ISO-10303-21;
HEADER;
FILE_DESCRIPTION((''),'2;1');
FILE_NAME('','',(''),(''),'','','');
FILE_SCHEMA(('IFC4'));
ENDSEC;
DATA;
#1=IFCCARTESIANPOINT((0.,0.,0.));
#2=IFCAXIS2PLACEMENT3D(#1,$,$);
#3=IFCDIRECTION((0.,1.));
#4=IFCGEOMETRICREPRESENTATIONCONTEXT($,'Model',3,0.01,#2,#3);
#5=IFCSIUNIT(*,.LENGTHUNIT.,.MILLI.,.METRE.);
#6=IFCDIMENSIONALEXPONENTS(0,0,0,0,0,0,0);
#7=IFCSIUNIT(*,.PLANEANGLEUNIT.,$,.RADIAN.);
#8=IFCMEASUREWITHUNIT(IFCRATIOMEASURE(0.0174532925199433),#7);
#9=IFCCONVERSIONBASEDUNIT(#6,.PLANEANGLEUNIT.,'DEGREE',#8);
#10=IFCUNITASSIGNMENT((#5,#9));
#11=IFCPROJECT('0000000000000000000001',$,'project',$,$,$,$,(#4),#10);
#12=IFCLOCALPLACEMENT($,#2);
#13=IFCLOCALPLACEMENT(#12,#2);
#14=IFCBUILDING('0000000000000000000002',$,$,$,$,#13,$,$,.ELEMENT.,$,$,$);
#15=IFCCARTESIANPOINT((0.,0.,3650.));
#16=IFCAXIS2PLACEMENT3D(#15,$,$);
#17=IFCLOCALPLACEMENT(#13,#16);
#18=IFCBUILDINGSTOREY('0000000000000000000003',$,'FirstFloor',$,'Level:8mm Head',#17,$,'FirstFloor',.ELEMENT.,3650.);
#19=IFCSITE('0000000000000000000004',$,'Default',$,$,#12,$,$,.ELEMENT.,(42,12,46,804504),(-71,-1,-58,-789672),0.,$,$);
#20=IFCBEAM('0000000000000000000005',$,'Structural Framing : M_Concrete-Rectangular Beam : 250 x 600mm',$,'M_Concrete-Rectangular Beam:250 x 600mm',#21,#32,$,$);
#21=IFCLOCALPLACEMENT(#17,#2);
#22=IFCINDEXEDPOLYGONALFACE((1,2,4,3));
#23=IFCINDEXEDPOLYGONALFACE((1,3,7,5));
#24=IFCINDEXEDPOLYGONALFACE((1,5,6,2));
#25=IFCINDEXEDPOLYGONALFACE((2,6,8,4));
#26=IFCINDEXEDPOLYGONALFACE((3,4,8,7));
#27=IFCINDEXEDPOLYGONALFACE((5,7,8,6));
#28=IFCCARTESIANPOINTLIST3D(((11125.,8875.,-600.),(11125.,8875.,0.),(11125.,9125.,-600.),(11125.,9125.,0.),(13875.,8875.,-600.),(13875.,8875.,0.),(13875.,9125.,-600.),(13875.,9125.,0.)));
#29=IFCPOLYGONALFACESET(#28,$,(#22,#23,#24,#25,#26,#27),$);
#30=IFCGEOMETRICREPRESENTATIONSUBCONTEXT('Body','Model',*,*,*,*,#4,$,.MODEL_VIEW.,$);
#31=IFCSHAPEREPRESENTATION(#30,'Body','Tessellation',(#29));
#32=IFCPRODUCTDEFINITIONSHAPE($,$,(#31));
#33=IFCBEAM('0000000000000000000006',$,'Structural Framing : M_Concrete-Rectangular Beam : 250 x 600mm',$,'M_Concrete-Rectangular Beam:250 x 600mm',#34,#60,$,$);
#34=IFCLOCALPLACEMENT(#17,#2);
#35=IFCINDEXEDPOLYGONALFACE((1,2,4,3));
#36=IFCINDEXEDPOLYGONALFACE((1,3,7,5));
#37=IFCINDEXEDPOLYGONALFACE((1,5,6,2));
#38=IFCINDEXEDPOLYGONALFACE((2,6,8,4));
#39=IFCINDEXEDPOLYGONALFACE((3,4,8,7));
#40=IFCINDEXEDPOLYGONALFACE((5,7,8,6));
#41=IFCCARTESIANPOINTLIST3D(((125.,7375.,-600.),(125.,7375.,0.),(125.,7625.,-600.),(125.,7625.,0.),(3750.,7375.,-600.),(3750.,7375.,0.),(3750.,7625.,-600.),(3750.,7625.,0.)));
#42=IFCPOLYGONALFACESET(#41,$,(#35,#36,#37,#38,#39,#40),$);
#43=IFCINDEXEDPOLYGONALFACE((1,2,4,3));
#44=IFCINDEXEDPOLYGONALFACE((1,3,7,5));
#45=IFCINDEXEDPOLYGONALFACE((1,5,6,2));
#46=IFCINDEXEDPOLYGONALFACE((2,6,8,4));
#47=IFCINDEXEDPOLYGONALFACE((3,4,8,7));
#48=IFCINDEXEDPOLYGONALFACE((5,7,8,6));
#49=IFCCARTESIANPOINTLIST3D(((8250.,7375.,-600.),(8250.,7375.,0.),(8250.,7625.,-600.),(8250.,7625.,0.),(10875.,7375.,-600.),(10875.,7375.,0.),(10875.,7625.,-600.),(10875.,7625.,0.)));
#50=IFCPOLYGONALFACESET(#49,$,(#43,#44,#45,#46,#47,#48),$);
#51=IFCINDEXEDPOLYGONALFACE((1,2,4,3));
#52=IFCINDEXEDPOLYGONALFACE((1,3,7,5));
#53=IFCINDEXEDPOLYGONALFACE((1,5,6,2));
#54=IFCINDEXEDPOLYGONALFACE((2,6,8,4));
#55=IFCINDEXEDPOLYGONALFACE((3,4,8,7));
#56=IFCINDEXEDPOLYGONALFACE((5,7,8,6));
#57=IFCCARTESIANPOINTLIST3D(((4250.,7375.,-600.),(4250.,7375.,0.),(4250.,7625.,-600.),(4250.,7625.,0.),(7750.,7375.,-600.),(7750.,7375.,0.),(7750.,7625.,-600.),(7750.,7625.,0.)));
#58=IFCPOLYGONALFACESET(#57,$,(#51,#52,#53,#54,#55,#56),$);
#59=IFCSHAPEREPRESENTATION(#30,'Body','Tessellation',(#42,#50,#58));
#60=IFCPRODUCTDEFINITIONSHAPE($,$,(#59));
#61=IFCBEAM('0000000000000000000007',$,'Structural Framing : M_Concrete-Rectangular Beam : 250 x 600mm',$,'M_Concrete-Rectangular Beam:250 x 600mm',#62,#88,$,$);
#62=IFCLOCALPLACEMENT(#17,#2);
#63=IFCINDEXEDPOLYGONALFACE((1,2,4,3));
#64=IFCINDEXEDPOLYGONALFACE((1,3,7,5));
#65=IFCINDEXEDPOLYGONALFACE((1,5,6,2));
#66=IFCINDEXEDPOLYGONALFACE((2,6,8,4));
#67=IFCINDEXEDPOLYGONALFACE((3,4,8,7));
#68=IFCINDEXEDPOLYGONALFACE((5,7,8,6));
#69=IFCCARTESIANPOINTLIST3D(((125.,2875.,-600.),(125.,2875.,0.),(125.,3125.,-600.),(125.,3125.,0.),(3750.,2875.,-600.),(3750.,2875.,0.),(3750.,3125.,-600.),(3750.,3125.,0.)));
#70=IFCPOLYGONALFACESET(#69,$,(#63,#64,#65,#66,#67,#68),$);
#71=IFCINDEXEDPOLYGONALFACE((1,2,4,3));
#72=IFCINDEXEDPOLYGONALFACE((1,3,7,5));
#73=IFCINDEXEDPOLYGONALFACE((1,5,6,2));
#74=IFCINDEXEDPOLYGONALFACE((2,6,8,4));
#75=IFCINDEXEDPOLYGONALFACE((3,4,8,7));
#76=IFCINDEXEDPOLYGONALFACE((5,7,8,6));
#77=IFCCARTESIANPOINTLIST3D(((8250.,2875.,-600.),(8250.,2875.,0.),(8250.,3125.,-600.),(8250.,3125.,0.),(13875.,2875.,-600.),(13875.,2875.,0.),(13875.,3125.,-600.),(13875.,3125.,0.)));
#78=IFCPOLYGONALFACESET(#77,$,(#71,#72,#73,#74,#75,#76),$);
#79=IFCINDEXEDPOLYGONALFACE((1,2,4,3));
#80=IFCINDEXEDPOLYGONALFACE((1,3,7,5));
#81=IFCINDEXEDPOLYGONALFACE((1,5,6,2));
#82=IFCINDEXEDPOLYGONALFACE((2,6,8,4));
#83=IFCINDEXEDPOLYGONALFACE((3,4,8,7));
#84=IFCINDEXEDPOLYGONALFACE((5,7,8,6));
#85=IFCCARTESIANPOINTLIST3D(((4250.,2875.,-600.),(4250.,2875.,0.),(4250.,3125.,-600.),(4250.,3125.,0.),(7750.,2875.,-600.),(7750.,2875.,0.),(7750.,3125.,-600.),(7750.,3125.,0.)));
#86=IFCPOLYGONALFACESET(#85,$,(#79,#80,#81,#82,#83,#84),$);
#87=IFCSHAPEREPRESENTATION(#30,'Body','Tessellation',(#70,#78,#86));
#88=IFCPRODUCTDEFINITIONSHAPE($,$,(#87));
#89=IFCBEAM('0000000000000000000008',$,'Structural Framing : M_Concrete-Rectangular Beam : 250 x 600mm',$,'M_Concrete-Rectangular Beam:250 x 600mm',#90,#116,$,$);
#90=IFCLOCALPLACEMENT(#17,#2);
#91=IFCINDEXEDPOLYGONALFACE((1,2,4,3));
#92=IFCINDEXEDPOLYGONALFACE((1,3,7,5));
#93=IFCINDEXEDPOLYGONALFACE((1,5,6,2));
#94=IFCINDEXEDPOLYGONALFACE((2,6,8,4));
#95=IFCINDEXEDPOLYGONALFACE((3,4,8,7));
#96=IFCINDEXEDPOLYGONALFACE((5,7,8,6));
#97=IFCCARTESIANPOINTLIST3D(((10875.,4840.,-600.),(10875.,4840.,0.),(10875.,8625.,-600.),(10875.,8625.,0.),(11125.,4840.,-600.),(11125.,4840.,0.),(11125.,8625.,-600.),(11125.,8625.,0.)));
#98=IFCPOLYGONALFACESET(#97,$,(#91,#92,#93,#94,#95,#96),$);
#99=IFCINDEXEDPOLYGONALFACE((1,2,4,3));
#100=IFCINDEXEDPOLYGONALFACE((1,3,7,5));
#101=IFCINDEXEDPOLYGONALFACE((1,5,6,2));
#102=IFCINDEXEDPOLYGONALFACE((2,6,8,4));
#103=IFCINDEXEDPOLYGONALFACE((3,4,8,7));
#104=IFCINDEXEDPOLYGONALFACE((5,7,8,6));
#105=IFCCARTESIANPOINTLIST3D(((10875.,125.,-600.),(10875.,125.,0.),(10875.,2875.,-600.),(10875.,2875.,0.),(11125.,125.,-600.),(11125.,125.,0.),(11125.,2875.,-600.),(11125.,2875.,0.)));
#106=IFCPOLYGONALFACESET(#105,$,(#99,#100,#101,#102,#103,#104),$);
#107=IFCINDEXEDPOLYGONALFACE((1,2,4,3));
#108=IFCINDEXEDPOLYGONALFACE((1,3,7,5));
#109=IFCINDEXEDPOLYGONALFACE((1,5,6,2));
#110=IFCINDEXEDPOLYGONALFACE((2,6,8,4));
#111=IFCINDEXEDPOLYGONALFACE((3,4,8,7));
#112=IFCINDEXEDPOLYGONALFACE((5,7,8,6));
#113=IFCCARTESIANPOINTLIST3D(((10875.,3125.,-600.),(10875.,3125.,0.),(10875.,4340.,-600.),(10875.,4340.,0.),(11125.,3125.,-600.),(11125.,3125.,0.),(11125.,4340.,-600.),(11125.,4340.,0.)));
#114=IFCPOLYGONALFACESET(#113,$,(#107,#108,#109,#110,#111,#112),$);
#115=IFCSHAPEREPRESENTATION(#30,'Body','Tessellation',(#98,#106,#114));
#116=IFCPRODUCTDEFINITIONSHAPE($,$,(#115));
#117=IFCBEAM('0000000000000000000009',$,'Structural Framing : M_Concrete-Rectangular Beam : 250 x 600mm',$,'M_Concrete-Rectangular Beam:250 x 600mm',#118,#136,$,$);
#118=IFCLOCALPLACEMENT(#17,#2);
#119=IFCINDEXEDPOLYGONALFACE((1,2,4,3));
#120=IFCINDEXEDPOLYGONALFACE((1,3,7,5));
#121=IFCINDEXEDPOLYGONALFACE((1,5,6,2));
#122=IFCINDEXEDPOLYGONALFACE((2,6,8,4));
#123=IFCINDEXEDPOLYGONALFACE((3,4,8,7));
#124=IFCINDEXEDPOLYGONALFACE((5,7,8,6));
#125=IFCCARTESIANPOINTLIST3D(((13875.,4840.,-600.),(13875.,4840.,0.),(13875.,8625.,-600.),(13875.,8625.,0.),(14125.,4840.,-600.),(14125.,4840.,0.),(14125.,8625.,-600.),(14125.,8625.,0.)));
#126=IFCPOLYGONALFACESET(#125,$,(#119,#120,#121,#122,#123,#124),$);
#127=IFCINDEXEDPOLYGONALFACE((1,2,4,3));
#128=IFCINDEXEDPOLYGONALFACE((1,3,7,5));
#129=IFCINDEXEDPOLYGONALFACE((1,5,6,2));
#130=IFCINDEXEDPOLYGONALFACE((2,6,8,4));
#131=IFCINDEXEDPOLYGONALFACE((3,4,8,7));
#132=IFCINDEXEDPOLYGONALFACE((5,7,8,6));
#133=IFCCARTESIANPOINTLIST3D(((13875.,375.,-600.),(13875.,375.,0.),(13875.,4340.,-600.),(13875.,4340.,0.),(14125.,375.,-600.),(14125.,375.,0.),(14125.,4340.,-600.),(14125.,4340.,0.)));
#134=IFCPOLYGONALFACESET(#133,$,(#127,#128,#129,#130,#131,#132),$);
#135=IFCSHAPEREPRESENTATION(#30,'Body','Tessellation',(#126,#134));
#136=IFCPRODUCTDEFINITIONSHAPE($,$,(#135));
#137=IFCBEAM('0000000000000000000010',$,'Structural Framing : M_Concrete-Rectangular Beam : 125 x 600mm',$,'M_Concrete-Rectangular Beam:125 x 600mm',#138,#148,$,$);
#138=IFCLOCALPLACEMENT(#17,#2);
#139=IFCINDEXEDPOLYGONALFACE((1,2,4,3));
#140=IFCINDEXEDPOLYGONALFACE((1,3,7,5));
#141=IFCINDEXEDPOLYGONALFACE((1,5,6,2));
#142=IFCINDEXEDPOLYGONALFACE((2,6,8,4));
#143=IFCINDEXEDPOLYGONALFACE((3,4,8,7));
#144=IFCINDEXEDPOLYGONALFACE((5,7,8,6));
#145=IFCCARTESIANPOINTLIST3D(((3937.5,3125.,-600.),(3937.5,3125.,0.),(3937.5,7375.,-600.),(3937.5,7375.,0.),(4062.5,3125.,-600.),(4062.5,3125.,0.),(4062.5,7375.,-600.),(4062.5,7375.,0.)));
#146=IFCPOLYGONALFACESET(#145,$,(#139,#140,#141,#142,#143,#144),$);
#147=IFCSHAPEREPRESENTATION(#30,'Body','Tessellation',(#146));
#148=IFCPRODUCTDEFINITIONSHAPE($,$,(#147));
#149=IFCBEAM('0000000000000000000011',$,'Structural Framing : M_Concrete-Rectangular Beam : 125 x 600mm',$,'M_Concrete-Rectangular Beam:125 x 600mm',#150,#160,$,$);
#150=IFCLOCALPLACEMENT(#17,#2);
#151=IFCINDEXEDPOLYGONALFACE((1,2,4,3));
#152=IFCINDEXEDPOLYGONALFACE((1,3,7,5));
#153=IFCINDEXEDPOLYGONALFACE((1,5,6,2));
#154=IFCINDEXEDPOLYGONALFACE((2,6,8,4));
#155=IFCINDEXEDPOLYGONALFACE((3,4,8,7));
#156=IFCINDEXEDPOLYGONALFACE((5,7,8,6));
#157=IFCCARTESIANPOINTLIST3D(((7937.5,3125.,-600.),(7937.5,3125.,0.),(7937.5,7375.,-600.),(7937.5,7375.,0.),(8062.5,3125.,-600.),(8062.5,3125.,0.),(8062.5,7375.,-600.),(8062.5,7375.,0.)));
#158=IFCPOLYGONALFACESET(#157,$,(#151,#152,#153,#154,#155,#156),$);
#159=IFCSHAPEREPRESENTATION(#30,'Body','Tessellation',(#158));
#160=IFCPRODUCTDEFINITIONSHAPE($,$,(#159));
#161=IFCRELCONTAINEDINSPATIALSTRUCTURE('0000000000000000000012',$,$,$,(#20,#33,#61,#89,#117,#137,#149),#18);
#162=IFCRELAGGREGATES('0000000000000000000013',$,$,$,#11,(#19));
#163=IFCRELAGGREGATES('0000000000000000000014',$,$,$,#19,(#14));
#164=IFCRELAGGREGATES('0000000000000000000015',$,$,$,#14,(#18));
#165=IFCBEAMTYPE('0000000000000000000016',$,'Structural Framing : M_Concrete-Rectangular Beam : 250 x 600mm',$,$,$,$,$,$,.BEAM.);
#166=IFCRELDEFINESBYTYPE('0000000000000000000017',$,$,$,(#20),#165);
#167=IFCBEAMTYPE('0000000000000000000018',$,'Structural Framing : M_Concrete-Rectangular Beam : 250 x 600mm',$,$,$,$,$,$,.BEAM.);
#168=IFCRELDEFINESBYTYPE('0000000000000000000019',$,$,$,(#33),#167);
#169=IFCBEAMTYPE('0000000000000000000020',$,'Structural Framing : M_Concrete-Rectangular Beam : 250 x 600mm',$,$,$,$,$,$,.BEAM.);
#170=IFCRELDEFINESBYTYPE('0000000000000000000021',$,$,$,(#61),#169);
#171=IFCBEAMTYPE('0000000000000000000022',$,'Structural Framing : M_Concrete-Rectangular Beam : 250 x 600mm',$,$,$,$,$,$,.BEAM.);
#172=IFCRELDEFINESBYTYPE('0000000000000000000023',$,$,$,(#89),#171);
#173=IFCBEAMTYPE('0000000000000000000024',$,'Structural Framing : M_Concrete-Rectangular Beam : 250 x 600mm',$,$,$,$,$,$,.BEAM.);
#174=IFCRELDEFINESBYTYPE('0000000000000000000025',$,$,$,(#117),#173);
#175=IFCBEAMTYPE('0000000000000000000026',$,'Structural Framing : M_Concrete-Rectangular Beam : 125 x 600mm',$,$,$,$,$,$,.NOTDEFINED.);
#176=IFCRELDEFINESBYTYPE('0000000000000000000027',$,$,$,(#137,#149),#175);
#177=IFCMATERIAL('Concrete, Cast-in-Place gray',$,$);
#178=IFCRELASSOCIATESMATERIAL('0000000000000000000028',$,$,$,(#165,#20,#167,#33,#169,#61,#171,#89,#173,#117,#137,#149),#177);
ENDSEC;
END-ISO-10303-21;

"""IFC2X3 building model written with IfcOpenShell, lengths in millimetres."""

from ifc_helpers import new_model, entity, si_unit, converted_unit, direction, frame, frame_2d, origin, place, context, subcontext, project, spatial, rectangle, extrude, source, transform, mapped, material, type_object, type_shapes, element, save


model = new_model("IFC2X3")

# Units and contexts
model_context = context("Model", 3, precision=0.01, world=origin(), true_north=direction((0.0, 1.0)))
body_context = subcontext(model_context, "Body", "Model", "MODEL_VIEW")
ifc_project = project(units=[si_unit("LENGTHUNIT", "METRE", prefix="MILLI"), converted_unit("PLANEANGLEUNIT", "DEGREE", entity("IfcRatioMeasure", 0.0174532925199433), si_unit("PLANEANGLEUNIT", "RADIAN"), dimensions=[0, 0, 0, 0, 0, 0, 0])], contexts=[model_context])

# Site, building, storey
site_placement = place(None, origin())
site = spatial("IfcSite", under=ifc_project, at=site_placement, Name="Default", CompositionType="ELEMENT", RefLatitude=(42, 12, 46, 804504), RefLongitude=(-71, -1, -58, -789672), RefElevation=0.0)
building_placement = place(site_placement, origin())
building = spatial("IfcBuilding", under=site, at=building_placement, CompositionType="ELEMENT")
storey_placement = place(building_placement, frame((0.0, 0.0, 3650.0)))
storey = spatial("IfcBuildingStorey", under=building, at=storey_placement, Name="FirstFloor", ObjectType="Level:8mm Head", LongName="FirstFloor", CompositionType="ELEMENT", Elevation=3650.0)

# Shared definitions
ifc_material = material(Name="Concrete, Cast-in-Place gray")

# Beams
beam_type_1 = type_object("IfcBeamType", Name="Structural Framing : M_Concrete-Rectangular Beam : 250 x 600mm", PredefinedType="BEAM", material=ifc_material)
beam_1_placement = place(storey_placement, frame((11000.0, 9000.0, 0.0)))
element("IfcBeam", 1, at=beam_1_placement, inside=storey, type_object=beam_type_1, material=ifc_material, Name="Structural Framing : M_Concrete-Rectangular Beam : 250 x 600mm", ObjectType="M_Concrete-Rectangular Beam:250 x 600mm", context=body_context, shape_type="SweptSolid", body=[
    extrude(rectangle(XDim=600.0, YDim=250.0, at=frame_2d((0.0, 0.0), x_axis=(1.0, 0.0))), frame((125.0, 0.0, -300.0), z_axis=(1.0, 0.0, 0.0), x_axis=(0.0, 0.0, -1.0)), (0.0, 0.0, 1.0), 2750.0),
])
beam_type_2 = type_object("IfcBeamType", Name="Structural Framing : M_Concrete-Rectangular Beam : 250 x 600mm", PredefinedType="BEAM", material=ifc_material)
shared_shape_1 = source(origin(), body_context, "Body", "SweptSolid", [
    extrude(rectangle(XDim=600.0, YDim=250.0, at=frame_2d((0.0, 0.0), x_axis=(1.0, 0.0))), frame((125.0, 7500.0, 3350.0), z_axis=(1.0, 0.0, 0.0), x_axis=(0.0, 0.0, -1.0)), (0.0, 0.0, 1.0), 3625.0),
    extrude(rectangle(XDim=600.0, YDim=250.0, at=frame_2d((0.0, 0.0), x_axis=(1.0, 0.0))), frame((8250.0, 7500.0, 3350.0), z_axis=(1.0, 0.0, 0.0), x_axis=(0.0, 0.0, -1.0)), (0.0, 0.0, 1.0), 2625.0),
    extrude(rectangle(XDim=600.0, YDim=250.0, at=frame_2d((0.0, 0.0), x_axis=(1.0, 0.0))), frame((4250.0, 7500.0, 3350.0), z_axis=(1.0, 0.0, 0.0), x_axis=(0.0, 0.0, -1.0)), (0.0, 0.0, 1.0), 3500.0),
])
type_shapes(beam_type_2, [shared_shape_1])
beam_2_placement = place(storey_placement, frame((0.0, 0.0, -3650.0)))
element("IfcBeam", 2, at=beam_2_placement, inside=storey, type_object=beam_type_2, material=ifc_material, Name="Structural Framing : M_Concrete-Rectangular Beam : 250 x 600mm", ObjectType="M_Concrete-Rectangular Beam:250 x 600mm", context=body_context, shape_type="MappedRepresentation", body=[
    mapped(shared_shape_1, transform((0.0, 0.0, 0.0), scale=1.0)),
])
beam_type_3 = type_object("IfcBeamType", Name="Structural Framing : M_Concrete-Rectangular Beam : 250 x 600mm", PredefinedType="BEAM", material=ifc_material)
shared_shape_2 = source(origin(), body_context, "Body", "SweptSolid", [
    extrude(rectangle(XDim=600.0, YDim=250.0, at=frame_2d((0.0, 0.0), x_axis=(1.0, 0.0))), frame((125.0, 3000.0, 3350.0), z_axis=(1.0, 0.0, 0.0), x_axis=(0.0, 0.0, -1.0)), (0.0, 0.0, 1.0), 3625.0),
    extrude(rectangle(XDim=600.0, YDim=250.0, at=frame_2d((0.0, 0.0), x_axis=(1.0, 0.0))), frame((8250.0, 3000.0, 3350.0), z_axis=(1.0, 0.0, 0.0), x_axis=(0.0, 0.0, -1.0)), (0.0, 0.0, 1.0), 5625.0),
    extrude(rectangle(XDim=600.0, YDim=250.0, at=frame_2d((0.0, 0.0), x_axis=(1.0, 0.0))), frame((4250.0, 3000.0, 3350.0), z_axis=(1.0, 0.0, 0.0), x_axis=(0.0, 0.0, -1.0)), (0.0, 0.0, 1.0), 3500.0),
])
type_shapes(beam_type_3, [shared_shape_2])
beam_3_placement = place(storey_placement, frame((0.0, 0.0, -3650.0)))
element("IfcBeam", 3, at=beam_3_placement, inside=storey, type_object=beam_type_3, material=ifc_material, Name="Structural Framing : M_Concrete-Rectangular Beam : 250 x 600mm", ObjectType="M_Concrete-Rectangular Beam:250 x 600mm", context=body_context, shape_type="MappedRepresentation", body=[
    mapped(shared_shape_2, transform((0.0, 0.0, 0.0), scale=1.0)),
])
beam_type_4 = type_object("IfcBeamType", Name="Structural Framing : M_Concrete-Rectangular Beam : 250 x 600mm", PredefinedType="BEAM", material=ifc_material)
shared_shape_3 = source(origin(), body_context, "Body", "SweptSolid", [
    extrude(rectangle(XDim=600.0, YDim=250.0, at=frame_2d((0.0, 0.0), x_axis=(0.0, 1.0))), frame((11000.0, 4840.0, 3350.0), z_axis=(0.0, 1.0, 0.0), x_axis=(-1.0, 0.0, 0.0)), (0.0, 0.0, 1.0), 3785.0),
    extrude(rectangle(XDim=600.0, YDim=250.0, at=frame_2d((0.0, 0.0), x_axis=(0.0, 1.0))), frame((11000.0, 125.0, 3350.0), z_axis=(0.0, 1.0, 0.0), x_axis=(-1.0, 0.0, 0.0)), (0.0, 0.0, 1.0), 2750.0),
    extrude(rectangle(XDim=600.0, YDim=250.0, at=frame_2d((0.0, 0.0), x_axis=(0.0, 1.0))), frame((11000.0, 3125.0, 3350.0), z_axis=(0.0, 1.0, 0.0), x_axis=(-1.0, 0.0, 0.0)), (0.0, 0.0, 1.0), 1215.0),
])
type_shapes(beam_type_4, [shared_shape_3])
beam_4_placement = place(storey_placement, frame((0.0, 0.0, -3650.0)))
element("IfcBeam", 4, at=beam_4_placement, inside=storey, type_object=beam_type_4, material=ifc_material, Name="Structural Framing : M_Concrete-Rectangular Beam : 250 x 600mm", ObjectType="M_Concrete-Rectangular Beam:250 x 600mm", context=body_context, shape_type="MappedRepresentation", body=[
    mapped(shared_shape_3, transform((0.0, 0.0, 0.0), scale=1.0)),
])
beam_type_5 = type_object("IfcBeamType", Name="Structural Framing : M_Concrete-Rectangular Beam : 250 x 600mm", PredefinedType="BEAM", material=ifc_material)
shared_shape_4 = source(origin(), body_context, "Body", "SweptSolid", [
    extrude(rectangle(XDim=600.0, YDim=250.0, at=frame_2d((0.0, 0.0), x_axis=(0.0, 1.0))), frame((14000.0, 8625.0, 3350.0), z_axis=(0.0, -1.0, 0.0), x_axis=(-1.0, 0.0, 0.0)), (0.0, 0.0, 1.0), 3785.0),
    extrude(rectangle(XDim=600.0, YDim=250.0, at=frame_2d((0.0, 0.0), x_axis=(0.0, 1.0))), frame((14000.0, 4340.0, 3350.0), z_axis=(0.0, -1.0, 0.0), x_axis=(-1.0, 0.0, 0.0)), (0.0, 0.0, 1.0), 3965.0),
])
type_shapes(beam_type_5, [shared_shape_4])
beam_5_placement = place(storey_placement, frame((0.0, 0.0, -3650.0)))
element("IfcBeam", 5, at=beam_5_placement, inside=storey, type_object=beam_type_5, material=ifc_material, Name="Structural Framing : M_Concrete-Rectangular Beam : 250 x 600mm", ObjectType="M_Concrete-Rectangular Beam:250 x 600mm", context=body_context, shape_type="MappedRepresentation", body=[
    mapped(shared_shape_4, transform((0.0, 0.0, 0.0), scale=1.0)),
])
beam_type_6 = type_object("IfcBeamType", Name="Structural Framing : M_Concrete-Rectangular Beam : 125 x 600mm", PredefinedType="NOTDEFINED")
beam_6_placement = place(storey_placement, frame((4000.0, 3000.0, 0.0), z_axis=(0.0, 0.0, 1.0), x_axis=(0.0, 1.0, 0.0)))
element("IfcBeam", 6, at=beam_6_placement, inside=storey, type_object=beam_type_6, material=ifc_material, Name="Structural Framing : M_Concrete-Rectangular Beam : 125 x 600mm", ObjectType="M_Concrete-Rectangular Beam:125 x 600mm", context=body_context, shape_type="SweptSolid", body=[
    extrude(rectangle(XDim=600.0, YDim=125.0, at=frame_2d((0.0, 0.0), x_axis=(1.0, 0.0))), frame((125.0, 0.0, -300.0), z_axis=(1.0, 0.0, 0.0), x_axis=(0.0, 0.0, -1.0)), (0.0, 0.0, 1.0), 4250.0),
])
beam_7_placement = place(storey_placement, frame((8000.0, 3000.0, 0.0), z_axis=(0.0, 0.0, 1.0), x_axis=(0.0, 1.0, 0.0)))
element("IfcBeam", 7, at=beam_7_placement, inside=storey, type_object=beam_type_6, material=ifc_material, Name="Structural Framing : M_Concrete-Rectangular Beam : 125 x 600mm", ObjectType="M_Concrete-Rectangular Beam:125 x 600mm", context=body_context, shape_type="SweptSolid", body=[
    extrude(rectangle(XDim=600.0, YDim=125.0, at=frame_2d((0.0, 0.0), x_axis=(1.0, 0.0))), frame((125.0, 0.0, -300.0), z_axis=(1.0, 0.0, 0.0), x_axis=(0.0, 0.0, -1.0)), (0.0, 0.0, 1.0), 4250.0),
])

save(model, "model.ifc")
